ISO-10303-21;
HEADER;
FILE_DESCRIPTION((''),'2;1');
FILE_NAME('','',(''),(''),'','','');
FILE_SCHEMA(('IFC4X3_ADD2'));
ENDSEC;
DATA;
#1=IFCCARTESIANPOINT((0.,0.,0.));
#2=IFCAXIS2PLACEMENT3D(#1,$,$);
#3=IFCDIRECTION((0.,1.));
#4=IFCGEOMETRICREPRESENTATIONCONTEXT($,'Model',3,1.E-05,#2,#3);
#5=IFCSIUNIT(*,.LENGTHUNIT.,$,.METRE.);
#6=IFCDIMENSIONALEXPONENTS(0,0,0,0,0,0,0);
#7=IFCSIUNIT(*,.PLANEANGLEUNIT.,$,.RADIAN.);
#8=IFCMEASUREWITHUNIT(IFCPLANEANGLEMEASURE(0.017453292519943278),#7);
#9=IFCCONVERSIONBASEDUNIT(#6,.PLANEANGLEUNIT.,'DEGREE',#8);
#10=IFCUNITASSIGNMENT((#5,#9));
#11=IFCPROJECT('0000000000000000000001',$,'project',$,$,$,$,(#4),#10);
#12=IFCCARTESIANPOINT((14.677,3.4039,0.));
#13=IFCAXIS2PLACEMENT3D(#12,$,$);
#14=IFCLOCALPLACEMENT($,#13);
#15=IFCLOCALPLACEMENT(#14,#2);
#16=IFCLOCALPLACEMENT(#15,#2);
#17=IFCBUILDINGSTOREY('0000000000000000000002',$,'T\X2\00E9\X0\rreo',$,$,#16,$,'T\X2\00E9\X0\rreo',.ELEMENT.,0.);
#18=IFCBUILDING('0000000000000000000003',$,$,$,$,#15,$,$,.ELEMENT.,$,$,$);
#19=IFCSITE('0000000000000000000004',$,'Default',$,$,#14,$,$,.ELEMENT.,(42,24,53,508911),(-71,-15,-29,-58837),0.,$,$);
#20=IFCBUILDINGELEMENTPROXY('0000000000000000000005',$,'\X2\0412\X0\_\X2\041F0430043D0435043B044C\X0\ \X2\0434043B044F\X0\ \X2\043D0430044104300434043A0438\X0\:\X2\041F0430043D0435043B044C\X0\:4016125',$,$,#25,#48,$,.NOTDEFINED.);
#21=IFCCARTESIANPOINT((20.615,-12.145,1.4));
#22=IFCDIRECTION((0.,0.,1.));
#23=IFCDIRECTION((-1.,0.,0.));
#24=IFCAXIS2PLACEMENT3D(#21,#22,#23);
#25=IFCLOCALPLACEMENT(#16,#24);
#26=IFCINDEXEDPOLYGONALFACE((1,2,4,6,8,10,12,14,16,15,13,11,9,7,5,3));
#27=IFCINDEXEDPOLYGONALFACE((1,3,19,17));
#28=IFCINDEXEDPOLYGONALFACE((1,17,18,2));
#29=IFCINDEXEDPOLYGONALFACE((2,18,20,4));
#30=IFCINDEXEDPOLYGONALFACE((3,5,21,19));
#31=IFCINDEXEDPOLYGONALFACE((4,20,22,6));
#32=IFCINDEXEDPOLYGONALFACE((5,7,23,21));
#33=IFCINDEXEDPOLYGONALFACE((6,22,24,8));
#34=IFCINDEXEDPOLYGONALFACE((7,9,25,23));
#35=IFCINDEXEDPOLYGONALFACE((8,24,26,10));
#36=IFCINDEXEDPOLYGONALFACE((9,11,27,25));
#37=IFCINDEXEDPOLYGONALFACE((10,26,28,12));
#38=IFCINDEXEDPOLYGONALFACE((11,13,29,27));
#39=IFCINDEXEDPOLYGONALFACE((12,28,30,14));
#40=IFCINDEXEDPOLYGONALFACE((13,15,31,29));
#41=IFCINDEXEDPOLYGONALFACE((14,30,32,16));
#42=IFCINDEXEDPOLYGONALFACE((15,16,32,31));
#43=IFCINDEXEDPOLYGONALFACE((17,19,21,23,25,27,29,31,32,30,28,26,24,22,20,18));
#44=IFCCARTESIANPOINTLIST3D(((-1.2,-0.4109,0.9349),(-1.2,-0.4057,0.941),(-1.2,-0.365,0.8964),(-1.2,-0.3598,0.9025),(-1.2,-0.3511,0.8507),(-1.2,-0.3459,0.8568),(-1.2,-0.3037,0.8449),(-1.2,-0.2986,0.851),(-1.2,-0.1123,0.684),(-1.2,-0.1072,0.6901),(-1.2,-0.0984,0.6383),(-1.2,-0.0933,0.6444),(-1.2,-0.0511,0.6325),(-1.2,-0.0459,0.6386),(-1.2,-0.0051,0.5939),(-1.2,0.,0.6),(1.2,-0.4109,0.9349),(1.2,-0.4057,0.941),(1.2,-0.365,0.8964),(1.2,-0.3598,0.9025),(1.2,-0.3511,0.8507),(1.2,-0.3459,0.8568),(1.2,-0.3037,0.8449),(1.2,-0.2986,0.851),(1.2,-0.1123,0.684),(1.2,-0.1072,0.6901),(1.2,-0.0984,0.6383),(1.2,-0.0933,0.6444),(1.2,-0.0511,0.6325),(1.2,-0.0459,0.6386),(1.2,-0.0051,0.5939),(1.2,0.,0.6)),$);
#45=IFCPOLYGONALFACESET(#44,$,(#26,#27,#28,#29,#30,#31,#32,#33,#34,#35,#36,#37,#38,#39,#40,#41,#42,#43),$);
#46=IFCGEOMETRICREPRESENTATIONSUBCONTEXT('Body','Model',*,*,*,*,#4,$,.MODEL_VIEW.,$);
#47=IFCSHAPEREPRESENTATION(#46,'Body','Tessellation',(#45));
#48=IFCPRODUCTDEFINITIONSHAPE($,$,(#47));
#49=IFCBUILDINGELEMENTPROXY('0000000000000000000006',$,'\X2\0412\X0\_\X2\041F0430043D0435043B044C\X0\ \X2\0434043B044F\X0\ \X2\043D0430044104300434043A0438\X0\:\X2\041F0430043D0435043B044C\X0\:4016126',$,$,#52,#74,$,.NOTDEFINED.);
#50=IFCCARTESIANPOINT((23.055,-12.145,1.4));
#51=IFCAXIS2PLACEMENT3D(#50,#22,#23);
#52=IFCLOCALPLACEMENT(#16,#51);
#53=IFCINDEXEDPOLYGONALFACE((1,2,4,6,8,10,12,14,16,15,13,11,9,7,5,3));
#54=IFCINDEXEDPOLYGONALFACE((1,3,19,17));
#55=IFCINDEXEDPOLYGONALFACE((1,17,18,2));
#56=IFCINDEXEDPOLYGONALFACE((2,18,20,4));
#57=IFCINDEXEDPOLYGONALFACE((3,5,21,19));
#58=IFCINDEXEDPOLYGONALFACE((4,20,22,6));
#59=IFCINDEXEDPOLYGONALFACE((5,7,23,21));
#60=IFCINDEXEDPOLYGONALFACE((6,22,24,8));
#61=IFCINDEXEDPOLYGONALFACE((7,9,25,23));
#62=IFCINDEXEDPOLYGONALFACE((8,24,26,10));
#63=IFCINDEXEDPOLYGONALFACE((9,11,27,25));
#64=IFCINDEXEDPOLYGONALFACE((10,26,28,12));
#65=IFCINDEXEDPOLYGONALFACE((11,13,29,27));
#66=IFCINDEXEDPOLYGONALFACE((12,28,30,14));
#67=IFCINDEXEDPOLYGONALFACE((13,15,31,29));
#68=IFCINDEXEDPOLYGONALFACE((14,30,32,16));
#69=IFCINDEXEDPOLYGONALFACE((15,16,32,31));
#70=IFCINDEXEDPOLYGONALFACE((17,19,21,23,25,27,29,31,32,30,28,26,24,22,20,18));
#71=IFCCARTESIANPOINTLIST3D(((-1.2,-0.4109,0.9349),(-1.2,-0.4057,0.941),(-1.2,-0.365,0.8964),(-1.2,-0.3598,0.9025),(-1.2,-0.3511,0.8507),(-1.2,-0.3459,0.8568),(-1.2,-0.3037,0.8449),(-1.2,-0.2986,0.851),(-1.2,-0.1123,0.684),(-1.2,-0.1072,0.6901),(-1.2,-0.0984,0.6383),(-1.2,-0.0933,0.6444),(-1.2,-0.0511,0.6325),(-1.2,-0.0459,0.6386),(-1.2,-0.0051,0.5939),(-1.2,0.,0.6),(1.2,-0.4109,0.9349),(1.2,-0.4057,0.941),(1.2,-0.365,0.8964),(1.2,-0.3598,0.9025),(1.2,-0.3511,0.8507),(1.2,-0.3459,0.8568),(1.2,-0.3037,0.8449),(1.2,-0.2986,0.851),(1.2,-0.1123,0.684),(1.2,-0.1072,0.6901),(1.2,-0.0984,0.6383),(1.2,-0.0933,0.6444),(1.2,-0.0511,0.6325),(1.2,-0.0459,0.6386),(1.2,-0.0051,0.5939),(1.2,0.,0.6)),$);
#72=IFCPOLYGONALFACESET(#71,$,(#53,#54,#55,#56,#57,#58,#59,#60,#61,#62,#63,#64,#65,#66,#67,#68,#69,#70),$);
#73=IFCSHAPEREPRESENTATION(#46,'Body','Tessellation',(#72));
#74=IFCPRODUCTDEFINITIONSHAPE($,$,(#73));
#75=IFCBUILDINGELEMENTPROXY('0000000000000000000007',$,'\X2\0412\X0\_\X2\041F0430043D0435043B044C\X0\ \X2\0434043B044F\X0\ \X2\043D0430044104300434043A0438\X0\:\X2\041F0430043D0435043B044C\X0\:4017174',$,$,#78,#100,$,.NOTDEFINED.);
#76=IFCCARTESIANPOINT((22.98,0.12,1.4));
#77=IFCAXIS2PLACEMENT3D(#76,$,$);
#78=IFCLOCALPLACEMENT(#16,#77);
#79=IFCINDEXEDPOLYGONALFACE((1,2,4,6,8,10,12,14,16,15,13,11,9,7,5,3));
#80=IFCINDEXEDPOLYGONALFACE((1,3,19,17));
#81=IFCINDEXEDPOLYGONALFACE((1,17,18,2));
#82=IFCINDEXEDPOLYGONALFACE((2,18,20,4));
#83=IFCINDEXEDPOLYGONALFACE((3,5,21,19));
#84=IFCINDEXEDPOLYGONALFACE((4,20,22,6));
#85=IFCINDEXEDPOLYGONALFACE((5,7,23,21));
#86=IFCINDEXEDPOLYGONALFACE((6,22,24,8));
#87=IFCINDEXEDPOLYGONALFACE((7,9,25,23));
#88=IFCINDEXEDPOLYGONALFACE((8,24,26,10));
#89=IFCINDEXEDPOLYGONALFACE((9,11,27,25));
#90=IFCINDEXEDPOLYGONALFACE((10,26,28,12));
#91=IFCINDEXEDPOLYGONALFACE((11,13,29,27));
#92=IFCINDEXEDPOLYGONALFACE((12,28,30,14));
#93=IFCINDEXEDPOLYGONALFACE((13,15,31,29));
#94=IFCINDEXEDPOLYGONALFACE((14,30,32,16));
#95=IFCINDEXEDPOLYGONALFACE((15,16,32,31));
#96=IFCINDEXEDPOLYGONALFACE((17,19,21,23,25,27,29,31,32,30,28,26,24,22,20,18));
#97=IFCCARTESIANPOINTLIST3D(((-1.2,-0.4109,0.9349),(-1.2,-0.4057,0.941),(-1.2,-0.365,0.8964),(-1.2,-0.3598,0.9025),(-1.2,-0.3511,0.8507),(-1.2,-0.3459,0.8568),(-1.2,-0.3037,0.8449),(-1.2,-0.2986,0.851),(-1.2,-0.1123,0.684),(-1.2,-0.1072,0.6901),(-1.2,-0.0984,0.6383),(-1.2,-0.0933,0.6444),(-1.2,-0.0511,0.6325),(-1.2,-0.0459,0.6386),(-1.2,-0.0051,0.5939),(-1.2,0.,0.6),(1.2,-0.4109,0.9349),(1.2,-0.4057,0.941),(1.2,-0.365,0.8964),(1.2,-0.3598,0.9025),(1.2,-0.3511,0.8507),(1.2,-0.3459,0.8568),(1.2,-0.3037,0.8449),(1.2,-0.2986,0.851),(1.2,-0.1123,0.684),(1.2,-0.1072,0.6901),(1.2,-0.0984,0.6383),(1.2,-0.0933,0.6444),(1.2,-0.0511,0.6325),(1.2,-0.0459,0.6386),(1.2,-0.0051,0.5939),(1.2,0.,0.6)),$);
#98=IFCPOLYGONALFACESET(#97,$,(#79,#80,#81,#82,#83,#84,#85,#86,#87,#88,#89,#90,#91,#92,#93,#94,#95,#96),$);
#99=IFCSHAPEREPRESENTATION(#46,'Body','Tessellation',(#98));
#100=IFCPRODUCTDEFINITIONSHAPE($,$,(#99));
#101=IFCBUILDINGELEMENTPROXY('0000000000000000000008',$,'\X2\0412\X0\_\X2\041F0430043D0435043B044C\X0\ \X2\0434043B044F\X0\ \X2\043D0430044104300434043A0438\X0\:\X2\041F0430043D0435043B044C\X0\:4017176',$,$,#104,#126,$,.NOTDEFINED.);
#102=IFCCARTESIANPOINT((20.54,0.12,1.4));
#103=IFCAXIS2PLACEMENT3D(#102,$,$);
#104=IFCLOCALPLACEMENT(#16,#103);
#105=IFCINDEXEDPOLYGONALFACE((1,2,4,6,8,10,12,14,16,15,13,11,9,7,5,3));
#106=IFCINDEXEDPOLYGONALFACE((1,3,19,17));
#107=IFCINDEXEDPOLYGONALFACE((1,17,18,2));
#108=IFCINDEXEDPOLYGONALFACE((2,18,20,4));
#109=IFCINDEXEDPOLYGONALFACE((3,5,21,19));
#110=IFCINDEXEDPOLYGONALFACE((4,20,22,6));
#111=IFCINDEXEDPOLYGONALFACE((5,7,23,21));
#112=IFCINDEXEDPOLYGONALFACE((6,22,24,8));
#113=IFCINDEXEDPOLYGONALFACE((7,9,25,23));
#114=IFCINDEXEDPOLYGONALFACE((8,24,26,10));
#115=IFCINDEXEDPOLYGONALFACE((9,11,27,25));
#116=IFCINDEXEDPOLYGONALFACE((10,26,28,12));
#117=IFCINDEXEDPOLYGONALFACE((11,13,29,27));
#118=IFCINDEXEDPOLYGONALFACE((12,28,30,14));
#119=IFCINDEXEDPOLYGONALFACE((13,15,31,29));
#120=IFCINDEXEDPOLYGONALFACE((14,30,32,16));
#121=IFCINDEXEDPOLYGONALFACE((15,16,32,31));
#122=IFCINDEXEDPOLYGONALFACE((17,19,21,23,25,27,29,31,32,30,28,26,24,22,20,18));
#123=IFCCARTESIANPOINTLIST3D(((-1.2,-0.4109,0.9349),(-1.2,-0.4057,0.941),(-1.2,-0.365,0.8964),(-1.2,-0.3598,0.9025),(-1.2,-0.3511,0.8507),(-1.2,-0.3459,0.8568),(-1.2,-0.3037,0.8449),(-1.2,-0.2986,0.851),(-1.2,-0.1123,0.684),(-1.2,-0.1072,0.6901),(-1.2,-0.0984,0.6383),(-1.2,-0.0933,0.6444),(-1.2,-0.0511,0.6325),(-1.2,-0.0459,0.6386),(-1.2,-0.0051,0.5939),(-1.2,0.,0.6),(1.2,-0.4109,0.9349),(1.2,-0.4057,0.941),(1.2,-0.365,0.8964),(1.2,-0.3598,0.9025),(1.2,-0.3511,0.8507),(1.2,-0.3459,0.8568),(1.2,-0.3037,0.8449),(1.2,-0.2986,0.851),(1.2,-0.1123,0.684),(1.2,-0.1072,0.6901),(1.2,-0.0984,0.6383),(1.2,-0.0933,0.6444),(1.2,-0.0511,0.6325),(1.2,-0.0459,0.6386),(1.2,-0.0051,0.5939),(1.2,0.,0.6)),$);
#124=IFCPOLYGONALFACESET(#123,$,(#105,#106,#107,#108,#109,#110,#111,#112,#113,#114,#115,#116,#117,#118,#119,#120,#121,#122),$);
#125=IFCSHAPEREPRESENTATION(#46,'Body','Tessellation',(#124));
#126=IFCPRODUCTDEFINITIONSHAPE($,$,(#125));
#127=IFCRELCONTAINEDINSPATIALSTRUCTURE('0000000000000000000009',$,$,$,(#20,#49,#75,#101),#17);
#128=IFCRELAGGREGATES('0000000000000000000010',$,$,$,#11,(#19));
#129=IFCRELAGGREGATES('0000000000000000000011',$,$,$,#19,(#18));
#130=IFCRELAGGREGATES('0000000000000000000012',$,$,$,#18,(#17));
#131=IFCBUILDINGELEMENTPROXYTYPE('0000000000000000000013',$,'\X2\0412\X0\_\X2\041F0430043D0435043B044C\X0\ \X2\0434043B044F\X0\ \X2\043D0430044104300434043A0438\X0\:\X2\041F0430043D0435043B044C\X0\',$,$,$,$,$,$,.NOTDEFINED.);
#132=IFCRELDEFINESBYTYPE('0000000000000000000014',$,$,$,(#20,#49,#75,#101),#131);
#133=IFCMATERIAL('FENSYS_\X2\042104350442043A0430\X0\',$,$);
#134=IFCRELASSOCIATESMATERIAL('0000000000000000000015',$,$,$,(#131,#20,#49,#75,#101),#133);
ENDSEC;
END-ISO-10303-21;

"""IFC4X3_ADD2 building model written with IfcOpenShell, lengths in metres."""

from ifc_helpers import new_model, entity, si_unit, converted_unit, direction, frame, origin, place, context, subcontext, project, spatial, polyline, outline, extrude, source, transform, mapped, material, type_object, type_shapes, element, save


model = new_model("IFC4X3_ADD2")

# Units and contexts
model_context = context("Model", 3, precision=1e-05, world=origin(), true_north=direction((0.0, 1.0)))
body_context = subcontext(model_context, "Body", "Model", "MODEL_VIEW")
ifc_project = project(units=[si_unit("LENGTHUNIT", "METRE"), converted_unit("PLANEANGLEUNIT", "DEGREE", entity("IfcPlaneAngleMeasure", 0.017453292519943278), si_unit("PLANEANGLEUNIT", "RADIAN"), dimensions=[0, 0, 0, 0, 0, 0, 0])], contexts=[model_context])

# Site, building, storey
site_placement = place(None, frame((14.677, 3.4039, 0.0)))
site = spatial("IfcSite", under=ifc_project, at=site_placement, Name="Default", CompositionType="ELEMENT", RefLatitude=(42, 24, 53, 508911), RefLongitude=(-71, -15, -29, -58837), RefElevation=0.0)
building_placement = place(site_placement, origin())
building = spatial("IfcBuilding", under=site, at=building_placement, CompositionType="ELEMENT")
storey_placement = place(building_placement, origin())
storey = spatial("IfcBuildingStorey", under=building, at=storey_placement, Name="Térreo", LongName="Térreo", CompositionType="ELEMENT", Elevation=0.0)

# Building element proxies
ifc_material_1 = material(Name="FENSYS_Сетка")
building_element_proxy_type_1 = type_object("IfcBuildingElementProxyType", Name="В_Панель для насадки:Панель", PredefinedType="NOTDEFINED", material=ifc_material_1)
shared_shape_1 = source(origin(), body_context, "Body", "SweptSolid", [
    extrude(outline(polyline([(0.205, -0.0105), (0.265, -0.0105), (0.265, -0.0025), (0.205, -0.0025), (0.165, 0.0235), (0.125, -0.0025), (-0.125, -0.0025), (-0.165, 0.0235), (-0.205, -0.0025), (-0.265, -0.0025), (-0.265, -0.0105), (-0.205, -0.0105), (-0.165, 0.0155), (-0.125, -0.0105), (0.125, -0.0105), (0.165, 0.0155), (0.205, -0.0105)])), frame((-1.2, -0.2096, 0.7625), z_axis=(1.0, 0.0, 0.0), x_axis=(0.0, -0.765483, 0.643456)), (0.0, 0.0, 1.0), 2.4),
])
type_shapes(building_element_proxy_type_1, [shared_shape_1])
for number, where, z_axis, x_axis, name in (
    (1, (20.615, -12.145, 1.4), (0.0, 0.0, 1.0), (-1.0, 0.0, 0.0), "В_Панель для насадки:Панель:4016125"),
    (2, (23.055, -12.145, 1.4), (0.0, 0.0, 1.0), (-1.0, 0.0, 0.0), "В_Панель для насадки:Панель:4016126"),
):
    element("IfcBuildingElementProxy", number, at=place(storey_placement, frame(where, z_axis=z_axis, x_axis=x_axis)), inside=storey, type_object=building_element_proxy_type_1, material=ifc_material_1, Name=name, PredefinedType="NOTDEFINED", context=body_context, shape_type="MappedRepresentation", body=[
        mapped(shared_shape_1, transform((0.0, 0.0, 0.0), scale=1.0)),
    ])
for number, where, name in (
    (3, (22.98, 0.12, 1.4), "В_Панель для насадки:Панель:4017174"),
    (4, (20.54, 0.12, 1.4), "В_Панель для насадки:Панель:4017176"),
):
    element("IfcBuildingElementProxy", number, at=place(storey_placement, frame(where)), inside=storey, type_object=building_element_proxy_type_1, material=ifc_material_1, Name=name, PredefinedType="NOTDEFINED", context=body_context, shape_type="MappedRepresentation", body=[
        mapped(shared_shape_1, transform((0.0, 0.0, 0.0), scale=1.0)),
    ])

save(model, "model.ifc")
